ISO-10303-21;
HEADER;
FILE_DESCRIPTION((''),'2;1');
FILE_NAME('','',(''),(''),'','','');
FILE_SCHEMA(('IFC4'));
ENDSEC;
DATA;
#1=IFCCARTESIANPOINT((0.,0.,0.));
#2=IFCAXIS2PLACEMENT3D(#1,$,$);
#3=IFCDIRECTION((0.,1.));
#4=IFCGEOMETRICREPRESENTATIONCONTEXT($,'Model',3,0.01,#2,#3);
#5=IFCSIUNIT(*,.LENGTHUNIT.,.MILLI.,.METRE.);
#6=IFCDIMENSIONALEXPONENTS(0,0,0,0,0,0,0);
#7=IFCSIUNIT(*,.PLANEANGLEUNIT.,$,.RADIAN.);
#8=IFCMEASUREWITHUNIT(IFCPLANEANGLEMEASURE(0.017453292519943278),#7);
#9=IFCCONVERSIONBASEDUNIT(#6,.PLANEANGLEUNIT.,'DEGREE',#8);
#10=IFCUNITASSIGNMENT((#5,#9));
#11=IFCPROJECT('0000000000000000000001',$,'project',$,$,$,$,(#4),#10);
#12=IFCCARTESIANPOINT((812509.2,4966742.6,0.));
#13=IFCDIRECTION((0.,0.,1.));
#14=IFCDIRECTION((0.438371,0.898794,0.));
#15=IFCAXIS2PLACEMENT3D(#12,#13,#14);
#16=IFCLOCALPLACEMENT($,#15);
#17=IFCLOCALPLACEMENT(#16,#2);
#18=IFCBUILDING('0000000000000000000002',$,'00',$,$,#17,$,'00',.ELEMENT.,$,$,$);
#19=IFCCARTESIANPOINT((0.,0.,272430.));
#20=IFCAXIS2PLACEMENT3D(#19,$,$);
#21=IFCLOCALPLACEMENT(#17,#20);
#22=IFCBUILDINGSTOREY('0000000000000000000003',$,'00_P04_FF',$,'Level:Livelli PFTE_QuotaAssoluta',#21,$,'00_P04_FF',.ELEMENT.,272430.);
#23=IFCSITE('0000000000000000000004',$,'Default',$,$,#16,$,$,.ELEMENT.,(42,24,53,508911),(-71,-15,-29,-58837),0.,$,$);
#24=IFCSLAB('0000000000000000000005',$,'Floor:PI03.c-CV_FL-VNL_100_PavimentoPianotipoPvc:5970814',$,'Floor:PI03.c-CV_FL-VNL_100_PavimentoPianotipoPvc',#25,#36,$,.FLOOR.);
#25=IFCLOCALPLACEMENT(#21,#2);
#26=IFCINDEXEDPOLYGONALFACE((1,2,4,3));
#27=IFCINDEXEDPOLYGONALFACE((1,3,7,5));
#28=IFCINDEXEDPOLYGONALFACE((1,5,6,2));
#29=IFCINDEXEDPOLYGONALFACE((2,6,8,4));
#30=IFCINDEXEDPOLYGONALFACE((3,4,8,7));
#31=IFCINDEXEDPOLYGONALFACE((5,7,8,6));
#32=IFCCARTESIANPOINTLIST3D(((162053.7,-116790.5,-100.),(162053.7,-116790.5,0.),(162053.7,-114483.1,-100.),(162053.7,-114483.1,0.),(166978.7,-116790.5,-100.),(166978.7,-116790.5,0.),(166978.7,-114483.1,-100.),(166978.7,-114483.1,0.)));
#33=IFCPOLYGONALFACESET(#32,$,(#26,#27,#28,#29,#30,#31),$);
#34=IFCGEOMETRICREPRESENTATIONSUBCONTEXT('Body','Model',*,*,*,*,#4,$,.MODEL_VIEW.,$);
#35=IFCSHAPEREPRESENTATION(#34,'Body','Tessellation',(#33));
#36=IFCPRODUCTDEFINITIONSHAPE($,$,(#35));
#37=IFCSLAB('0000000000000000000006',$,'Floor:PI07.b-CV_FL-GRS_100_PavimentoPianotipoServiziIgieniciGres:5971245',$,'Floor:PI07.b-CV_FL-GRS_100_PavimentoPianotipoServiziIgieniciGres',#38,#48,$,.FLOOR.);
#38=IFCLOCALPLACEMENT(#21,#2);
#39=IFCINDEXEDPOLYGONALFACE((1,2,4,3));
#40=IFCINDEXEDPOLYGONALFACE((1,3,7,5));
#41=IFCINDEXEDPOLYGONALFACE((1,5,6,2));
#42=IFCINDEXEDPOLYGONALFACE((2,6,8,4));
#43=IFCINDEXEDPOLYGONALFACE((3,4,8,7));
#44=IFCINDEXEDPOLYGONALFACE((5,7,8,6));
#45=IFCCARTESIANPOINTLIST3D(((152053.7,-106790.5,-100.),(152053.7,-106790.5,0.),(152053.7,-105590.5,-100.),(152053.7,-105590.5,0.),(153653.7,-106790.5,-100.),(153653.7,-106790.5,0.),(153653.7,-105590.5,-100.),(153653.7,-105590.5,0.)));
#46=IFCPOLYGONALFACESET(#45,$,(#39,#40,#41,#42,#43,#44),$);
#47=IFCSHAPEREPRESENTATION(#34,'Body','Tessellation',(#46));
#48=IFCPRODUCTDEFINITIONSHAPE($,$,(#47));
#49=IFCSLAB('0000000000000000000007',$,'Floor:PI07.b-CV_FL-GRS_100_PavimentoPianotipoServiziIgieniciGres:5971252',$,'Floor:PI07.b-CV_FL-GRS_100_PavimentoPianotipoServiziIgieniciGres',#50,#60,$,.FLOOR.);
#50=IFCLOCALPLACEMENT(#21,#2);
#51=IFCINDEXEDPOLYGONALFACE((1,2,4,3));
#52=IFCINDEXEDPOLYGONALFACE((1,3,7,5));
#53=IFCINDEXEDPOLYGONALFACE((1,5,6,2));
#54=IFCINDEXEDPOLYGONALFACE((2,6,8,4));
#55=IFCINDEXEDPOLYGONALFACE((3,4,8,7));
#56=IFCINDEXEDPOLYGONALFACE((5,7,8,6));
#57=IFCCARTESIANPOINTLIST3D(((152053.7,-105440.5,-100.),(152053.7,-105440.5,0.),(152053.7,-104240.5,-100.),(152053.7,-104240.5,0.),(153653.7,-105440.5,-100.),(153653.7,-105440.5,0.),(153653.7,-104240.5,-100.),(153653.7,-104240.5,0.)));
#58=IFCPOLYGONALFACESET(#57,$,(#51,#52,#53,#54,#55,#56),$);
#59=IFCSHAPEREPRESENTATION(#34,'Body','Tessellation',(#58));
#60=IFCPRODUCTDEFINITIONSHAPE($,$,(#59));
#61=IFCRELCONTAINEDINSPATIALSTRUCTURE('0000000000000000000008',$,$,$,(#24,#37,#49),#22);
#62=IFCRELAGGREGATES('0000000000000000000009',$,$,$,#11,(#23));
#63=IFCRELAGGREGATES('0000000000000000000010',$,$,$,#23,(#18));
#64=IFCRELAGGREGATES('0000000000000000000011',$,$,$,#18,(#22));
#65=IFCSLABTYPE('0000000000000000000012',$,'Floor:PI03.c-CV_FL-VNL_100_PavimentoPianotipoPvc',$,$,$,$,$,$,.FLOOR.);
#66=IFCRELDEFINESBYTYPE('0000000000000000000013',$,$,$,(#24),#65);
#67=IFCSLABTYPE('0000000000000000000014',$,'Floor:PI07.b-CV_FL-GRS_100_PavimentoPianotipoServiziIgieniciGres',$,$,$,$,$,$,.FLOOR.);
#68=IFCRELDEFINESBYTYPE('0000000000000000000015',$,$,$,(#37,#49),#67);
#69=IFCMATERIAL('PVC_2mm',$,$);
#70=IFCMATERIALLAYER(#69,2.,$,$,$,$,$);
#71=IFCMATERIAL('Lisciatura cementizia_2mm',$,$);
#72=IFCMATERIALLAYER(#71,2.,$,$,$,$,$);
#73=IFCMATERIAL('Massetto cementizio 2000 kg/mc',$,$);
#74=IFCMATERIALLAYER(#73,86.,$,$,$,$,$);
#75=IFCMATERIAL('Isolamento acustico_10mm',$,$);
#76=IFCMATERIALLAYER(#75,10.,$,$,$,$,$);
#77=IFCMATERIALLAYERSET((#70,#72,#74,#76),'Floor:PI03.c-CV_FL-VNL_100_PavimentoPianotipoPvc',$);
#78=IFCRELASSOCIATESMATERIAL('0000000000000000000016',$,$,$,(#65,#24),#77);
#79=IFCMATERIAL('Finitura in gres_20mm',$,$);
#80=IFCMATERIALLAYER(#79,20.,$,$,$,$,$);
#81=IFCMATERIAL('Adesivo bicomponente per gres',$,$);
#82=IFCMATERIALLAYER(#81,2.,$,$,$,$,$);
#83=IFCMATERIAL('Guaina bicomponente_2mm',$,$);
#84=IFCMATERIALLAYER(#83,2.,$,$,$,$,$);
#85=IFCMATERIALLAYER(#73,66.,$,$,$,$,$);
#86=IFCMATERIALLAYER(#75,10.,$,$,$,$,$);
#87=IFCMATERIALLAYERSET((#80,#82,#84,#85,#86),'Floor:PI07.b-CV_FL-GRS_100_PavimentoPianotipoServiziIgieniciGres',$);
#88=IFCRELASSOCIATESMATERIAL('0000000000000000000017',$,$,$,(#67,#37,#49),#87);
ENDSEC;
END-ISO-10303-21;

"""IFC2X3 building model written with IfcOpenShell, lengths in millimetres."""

from ifc_helpers import new_model, entity, si_unit, converted_unit, direction, frame, frame_2d, origin, origin_2d_with_axis, place, context, subcontext, project, spatial, rectangle, extrude, material, layer, layer_set, layer_usage, type_object, element, save


model = new_model("IFC2X3")

# Units and contexts
model_context = context("Model", 3, precision=0.01, world=origin(), true_north=direction((0.0, 1.0)))
body_context = subcontext(model_context, "Body", "Model", "MODEL_VIEW")
ifc_project = project(units=[si_unit("LENGTHUNIT", "METRE", prefix="MILLI"), converted_unit("PLANEANGLEUNIT", "DEGREE", entity("IfcPlaneAngleMeasure", 0.017453292519943278), si_unit("PLANEANGLEUNIT", "RADIAN"), dimensions=[0, 0, 0, 0, 0, 0, 0])], contexts=[model_context])

# Site, building, storey
site_placement = place(None, frame((812509.2, 4966742.6, 0.0), z_axis=(0.0, 0.0, 1.0), x_axis=(0.438371, 0.898794, 0.0)))
site = spatial("IfcSite", under=ifc_project, at=site_placement, Name="Default", CompositionType="ELEMENT", RefLatitude=(42, 24, 53, 508911), RefLongitude=(-71, -15, -29, -58837), RefElevation=0.0)
building_placement = place(site_placement, origin())
building = spatial("IfcBuilding", under=site, at=building_placement, Name="00", LongName="00", CompositionType="ELEMENT")
storey_placement = place(building_placement, frame((0.0, 0.0, 272430.0)))
storey = spatial("IfcBuildingStorey", under=building, at=storey_placement, Name="00_P04_FF", ObjectType="Level:Livelli PFTE_QuotaAssoluta", LongName="00_P04_FF", CompositionType="ELEMENT", Elevation=272430.0)

# Shared definitions
ifc_material_1 = material(Name="PVC_2mm")
ifc_layer_1 = layer(ifc_material_1, 2.0)
ifc_material_2 = material(Name="Lisciatura cementizia_2mm")
ifc_layer_2 = layer(ifc_material_2, 2.0)
ifc_material_3 = material(Name="Massetto cementizio 2000 kg/mc")
ifc_layer_3 = layer(ifc_material_3, 86.0)
ifc_material_4 = material(Name="Isolamento acustico_10mm")
ifc_layer_4 = layer(ifc_material_4, 10.0)
ifc_layer_set_1 = layer_set([ifc_layer_1, ifc_layer_2, ifc_layer_3, ifc_layer_4], Name="Floor:PI03.c-CV_FL-VNL_100_PavimentoPianotipoPvc")
slab_type_1 = type_object("IfcSlabType", Name="Floor:PI03.c-CV_FL-VNL_100_PavimentoPianotipoPvc", PredefinedType="FLOOR", material=ifc_layer_set_1)

# Slabs
ifc_layer_usage_1 = layer_usage(ifc_layer_set_1, "AXIS3", "POSITIVE", 0.0)
slab_1_placement = place(storey_placement, origin())
element("IfcSlab", 1, at=slab_1_placement, inside=storey, type_object=slab_type_1, material=ifc_layer_usage_1, Name="Floor:PI03.c-CV_FL-VNL_100_PavimentoPianotipoPvc:5970814", ObjectType="Floor:PI03.c-CV_FL-VNL_100_PavimentoPianotipoPvc", PredefinedType="FLOOR", context=body_context, shape_type="SweptSolid", body=[
    extrude(rectangle(XDim=2307.4, YDim=4925.0, at=origin_2d_with_axis()), frame((164516.2, -115636.8, 0.0), z_axis=(0.0, 0.0, -1.0), x_axis=(0.0, 1.0, 0.0)), (0.0, 0.0, 1.0), 100.0),
])
ifc_material_5 = material(Name="Finitura in gres_20mm")
ifc_layer_5 = layer(ifc_material_5, 20.0)
ifc_material_6 = material(Name="Adesivo bicomponente per gres")
ifc_layer_6 = layer(ifc_material_6, 2.0)
ifc_material_7 = material(Name="Guaina bicomponente_2mm")
ifc_layer_7 = layer(ifc_material_7, 2.0)
ifc_layer_8 = layer(ifc_material_3, 66.0)
ifc_layer_9 = layer(ifc_material_4, 10.0)
ifc_layer_set_2 = layer_set([ifc_layer_5, ifc_layer_6, ifc_layer_7, ifc_layer_8, ifc_layer_9], Name="Floor:PI07.b-CV_FL-GRS_100_PavimentoPianotipoServiziIgieniciGres")
slab_type_2 = type_object("IfcSlabType", Name="Floor:PI07.b-CV_FL-GRS_100_PavimentoPianotipoServiziIgieniciGres", PredefinedType="FLOOR", material=ifc_layer_set_2)
ifc_layer_usage_2 = layer_usage(ifc_layer_set_2, "AXIS3", "POSITIVE", 0.0)
slab_2_placement = place(storey_placement, origin())
element("IfcSlab", 2, at=slab_2_placement, inside=storey, type_object=slab_type_2, material=ifc_layer_usage_2, Name="Floor:PI07.b-CV_FL-GRS_100_PavimentoPianotipoServiziIgieniciGres:5971245", ObjectType="Floor:PI07.b-CV_FL-GRS_100_PavimentoPianotipoServiziIgieniciGres", PredefinedType="FLOOR", context=body_context, shape_type="SweptSolid", body=[
    extrude(rectangle(XDim=1200.0, YDim=1600.0, at=origin_2d_with_axis()), frame((152853.7, -106190.5, 0.0), z_axis=(0.0, 0.0, -1.0), x_axis=(0.0, 1.0, 0.0)), (0.0, 0.0, 1.0), 100.0),
])
ifc_layer_usage_3 = layer_usage(ifc_layer_set_2, "AXIS3", "POSITIVE", 0.0)
slab_3_placement = place(storey_placement, origin())
element("IfcSlab", 3, at=slab_3_placement, inside=storey, type_object=slab_type_2, material=ifc_layer_usage_3, Name="Floor:PI07.b-CV_FL-GRS_100_PavimentoPianotipoServiziIgieniciGres:5971252", ObjectType="Floor:PI07.b-CV_FL-GRS_100_PavimentoPianotipoServiziIgieniciGres", PredefinedType="FLOOR", context=body_context, shape_type="SweptSolid", body=[
    extrude(rectangle(XDim=1200.0, YDim=1600.0, at=frame_2d((0.0, 0.0), x_axis=(1.0, 0.0))), frame((152853.7, -104840.5, 0.0), z_axis=(0.0, 0.0, -1.0), x_axis=(0.0, 1.0, 0.0)), (0.0, 0.0, 1.0), 100.0),
])

save(model, "model.ifc")
